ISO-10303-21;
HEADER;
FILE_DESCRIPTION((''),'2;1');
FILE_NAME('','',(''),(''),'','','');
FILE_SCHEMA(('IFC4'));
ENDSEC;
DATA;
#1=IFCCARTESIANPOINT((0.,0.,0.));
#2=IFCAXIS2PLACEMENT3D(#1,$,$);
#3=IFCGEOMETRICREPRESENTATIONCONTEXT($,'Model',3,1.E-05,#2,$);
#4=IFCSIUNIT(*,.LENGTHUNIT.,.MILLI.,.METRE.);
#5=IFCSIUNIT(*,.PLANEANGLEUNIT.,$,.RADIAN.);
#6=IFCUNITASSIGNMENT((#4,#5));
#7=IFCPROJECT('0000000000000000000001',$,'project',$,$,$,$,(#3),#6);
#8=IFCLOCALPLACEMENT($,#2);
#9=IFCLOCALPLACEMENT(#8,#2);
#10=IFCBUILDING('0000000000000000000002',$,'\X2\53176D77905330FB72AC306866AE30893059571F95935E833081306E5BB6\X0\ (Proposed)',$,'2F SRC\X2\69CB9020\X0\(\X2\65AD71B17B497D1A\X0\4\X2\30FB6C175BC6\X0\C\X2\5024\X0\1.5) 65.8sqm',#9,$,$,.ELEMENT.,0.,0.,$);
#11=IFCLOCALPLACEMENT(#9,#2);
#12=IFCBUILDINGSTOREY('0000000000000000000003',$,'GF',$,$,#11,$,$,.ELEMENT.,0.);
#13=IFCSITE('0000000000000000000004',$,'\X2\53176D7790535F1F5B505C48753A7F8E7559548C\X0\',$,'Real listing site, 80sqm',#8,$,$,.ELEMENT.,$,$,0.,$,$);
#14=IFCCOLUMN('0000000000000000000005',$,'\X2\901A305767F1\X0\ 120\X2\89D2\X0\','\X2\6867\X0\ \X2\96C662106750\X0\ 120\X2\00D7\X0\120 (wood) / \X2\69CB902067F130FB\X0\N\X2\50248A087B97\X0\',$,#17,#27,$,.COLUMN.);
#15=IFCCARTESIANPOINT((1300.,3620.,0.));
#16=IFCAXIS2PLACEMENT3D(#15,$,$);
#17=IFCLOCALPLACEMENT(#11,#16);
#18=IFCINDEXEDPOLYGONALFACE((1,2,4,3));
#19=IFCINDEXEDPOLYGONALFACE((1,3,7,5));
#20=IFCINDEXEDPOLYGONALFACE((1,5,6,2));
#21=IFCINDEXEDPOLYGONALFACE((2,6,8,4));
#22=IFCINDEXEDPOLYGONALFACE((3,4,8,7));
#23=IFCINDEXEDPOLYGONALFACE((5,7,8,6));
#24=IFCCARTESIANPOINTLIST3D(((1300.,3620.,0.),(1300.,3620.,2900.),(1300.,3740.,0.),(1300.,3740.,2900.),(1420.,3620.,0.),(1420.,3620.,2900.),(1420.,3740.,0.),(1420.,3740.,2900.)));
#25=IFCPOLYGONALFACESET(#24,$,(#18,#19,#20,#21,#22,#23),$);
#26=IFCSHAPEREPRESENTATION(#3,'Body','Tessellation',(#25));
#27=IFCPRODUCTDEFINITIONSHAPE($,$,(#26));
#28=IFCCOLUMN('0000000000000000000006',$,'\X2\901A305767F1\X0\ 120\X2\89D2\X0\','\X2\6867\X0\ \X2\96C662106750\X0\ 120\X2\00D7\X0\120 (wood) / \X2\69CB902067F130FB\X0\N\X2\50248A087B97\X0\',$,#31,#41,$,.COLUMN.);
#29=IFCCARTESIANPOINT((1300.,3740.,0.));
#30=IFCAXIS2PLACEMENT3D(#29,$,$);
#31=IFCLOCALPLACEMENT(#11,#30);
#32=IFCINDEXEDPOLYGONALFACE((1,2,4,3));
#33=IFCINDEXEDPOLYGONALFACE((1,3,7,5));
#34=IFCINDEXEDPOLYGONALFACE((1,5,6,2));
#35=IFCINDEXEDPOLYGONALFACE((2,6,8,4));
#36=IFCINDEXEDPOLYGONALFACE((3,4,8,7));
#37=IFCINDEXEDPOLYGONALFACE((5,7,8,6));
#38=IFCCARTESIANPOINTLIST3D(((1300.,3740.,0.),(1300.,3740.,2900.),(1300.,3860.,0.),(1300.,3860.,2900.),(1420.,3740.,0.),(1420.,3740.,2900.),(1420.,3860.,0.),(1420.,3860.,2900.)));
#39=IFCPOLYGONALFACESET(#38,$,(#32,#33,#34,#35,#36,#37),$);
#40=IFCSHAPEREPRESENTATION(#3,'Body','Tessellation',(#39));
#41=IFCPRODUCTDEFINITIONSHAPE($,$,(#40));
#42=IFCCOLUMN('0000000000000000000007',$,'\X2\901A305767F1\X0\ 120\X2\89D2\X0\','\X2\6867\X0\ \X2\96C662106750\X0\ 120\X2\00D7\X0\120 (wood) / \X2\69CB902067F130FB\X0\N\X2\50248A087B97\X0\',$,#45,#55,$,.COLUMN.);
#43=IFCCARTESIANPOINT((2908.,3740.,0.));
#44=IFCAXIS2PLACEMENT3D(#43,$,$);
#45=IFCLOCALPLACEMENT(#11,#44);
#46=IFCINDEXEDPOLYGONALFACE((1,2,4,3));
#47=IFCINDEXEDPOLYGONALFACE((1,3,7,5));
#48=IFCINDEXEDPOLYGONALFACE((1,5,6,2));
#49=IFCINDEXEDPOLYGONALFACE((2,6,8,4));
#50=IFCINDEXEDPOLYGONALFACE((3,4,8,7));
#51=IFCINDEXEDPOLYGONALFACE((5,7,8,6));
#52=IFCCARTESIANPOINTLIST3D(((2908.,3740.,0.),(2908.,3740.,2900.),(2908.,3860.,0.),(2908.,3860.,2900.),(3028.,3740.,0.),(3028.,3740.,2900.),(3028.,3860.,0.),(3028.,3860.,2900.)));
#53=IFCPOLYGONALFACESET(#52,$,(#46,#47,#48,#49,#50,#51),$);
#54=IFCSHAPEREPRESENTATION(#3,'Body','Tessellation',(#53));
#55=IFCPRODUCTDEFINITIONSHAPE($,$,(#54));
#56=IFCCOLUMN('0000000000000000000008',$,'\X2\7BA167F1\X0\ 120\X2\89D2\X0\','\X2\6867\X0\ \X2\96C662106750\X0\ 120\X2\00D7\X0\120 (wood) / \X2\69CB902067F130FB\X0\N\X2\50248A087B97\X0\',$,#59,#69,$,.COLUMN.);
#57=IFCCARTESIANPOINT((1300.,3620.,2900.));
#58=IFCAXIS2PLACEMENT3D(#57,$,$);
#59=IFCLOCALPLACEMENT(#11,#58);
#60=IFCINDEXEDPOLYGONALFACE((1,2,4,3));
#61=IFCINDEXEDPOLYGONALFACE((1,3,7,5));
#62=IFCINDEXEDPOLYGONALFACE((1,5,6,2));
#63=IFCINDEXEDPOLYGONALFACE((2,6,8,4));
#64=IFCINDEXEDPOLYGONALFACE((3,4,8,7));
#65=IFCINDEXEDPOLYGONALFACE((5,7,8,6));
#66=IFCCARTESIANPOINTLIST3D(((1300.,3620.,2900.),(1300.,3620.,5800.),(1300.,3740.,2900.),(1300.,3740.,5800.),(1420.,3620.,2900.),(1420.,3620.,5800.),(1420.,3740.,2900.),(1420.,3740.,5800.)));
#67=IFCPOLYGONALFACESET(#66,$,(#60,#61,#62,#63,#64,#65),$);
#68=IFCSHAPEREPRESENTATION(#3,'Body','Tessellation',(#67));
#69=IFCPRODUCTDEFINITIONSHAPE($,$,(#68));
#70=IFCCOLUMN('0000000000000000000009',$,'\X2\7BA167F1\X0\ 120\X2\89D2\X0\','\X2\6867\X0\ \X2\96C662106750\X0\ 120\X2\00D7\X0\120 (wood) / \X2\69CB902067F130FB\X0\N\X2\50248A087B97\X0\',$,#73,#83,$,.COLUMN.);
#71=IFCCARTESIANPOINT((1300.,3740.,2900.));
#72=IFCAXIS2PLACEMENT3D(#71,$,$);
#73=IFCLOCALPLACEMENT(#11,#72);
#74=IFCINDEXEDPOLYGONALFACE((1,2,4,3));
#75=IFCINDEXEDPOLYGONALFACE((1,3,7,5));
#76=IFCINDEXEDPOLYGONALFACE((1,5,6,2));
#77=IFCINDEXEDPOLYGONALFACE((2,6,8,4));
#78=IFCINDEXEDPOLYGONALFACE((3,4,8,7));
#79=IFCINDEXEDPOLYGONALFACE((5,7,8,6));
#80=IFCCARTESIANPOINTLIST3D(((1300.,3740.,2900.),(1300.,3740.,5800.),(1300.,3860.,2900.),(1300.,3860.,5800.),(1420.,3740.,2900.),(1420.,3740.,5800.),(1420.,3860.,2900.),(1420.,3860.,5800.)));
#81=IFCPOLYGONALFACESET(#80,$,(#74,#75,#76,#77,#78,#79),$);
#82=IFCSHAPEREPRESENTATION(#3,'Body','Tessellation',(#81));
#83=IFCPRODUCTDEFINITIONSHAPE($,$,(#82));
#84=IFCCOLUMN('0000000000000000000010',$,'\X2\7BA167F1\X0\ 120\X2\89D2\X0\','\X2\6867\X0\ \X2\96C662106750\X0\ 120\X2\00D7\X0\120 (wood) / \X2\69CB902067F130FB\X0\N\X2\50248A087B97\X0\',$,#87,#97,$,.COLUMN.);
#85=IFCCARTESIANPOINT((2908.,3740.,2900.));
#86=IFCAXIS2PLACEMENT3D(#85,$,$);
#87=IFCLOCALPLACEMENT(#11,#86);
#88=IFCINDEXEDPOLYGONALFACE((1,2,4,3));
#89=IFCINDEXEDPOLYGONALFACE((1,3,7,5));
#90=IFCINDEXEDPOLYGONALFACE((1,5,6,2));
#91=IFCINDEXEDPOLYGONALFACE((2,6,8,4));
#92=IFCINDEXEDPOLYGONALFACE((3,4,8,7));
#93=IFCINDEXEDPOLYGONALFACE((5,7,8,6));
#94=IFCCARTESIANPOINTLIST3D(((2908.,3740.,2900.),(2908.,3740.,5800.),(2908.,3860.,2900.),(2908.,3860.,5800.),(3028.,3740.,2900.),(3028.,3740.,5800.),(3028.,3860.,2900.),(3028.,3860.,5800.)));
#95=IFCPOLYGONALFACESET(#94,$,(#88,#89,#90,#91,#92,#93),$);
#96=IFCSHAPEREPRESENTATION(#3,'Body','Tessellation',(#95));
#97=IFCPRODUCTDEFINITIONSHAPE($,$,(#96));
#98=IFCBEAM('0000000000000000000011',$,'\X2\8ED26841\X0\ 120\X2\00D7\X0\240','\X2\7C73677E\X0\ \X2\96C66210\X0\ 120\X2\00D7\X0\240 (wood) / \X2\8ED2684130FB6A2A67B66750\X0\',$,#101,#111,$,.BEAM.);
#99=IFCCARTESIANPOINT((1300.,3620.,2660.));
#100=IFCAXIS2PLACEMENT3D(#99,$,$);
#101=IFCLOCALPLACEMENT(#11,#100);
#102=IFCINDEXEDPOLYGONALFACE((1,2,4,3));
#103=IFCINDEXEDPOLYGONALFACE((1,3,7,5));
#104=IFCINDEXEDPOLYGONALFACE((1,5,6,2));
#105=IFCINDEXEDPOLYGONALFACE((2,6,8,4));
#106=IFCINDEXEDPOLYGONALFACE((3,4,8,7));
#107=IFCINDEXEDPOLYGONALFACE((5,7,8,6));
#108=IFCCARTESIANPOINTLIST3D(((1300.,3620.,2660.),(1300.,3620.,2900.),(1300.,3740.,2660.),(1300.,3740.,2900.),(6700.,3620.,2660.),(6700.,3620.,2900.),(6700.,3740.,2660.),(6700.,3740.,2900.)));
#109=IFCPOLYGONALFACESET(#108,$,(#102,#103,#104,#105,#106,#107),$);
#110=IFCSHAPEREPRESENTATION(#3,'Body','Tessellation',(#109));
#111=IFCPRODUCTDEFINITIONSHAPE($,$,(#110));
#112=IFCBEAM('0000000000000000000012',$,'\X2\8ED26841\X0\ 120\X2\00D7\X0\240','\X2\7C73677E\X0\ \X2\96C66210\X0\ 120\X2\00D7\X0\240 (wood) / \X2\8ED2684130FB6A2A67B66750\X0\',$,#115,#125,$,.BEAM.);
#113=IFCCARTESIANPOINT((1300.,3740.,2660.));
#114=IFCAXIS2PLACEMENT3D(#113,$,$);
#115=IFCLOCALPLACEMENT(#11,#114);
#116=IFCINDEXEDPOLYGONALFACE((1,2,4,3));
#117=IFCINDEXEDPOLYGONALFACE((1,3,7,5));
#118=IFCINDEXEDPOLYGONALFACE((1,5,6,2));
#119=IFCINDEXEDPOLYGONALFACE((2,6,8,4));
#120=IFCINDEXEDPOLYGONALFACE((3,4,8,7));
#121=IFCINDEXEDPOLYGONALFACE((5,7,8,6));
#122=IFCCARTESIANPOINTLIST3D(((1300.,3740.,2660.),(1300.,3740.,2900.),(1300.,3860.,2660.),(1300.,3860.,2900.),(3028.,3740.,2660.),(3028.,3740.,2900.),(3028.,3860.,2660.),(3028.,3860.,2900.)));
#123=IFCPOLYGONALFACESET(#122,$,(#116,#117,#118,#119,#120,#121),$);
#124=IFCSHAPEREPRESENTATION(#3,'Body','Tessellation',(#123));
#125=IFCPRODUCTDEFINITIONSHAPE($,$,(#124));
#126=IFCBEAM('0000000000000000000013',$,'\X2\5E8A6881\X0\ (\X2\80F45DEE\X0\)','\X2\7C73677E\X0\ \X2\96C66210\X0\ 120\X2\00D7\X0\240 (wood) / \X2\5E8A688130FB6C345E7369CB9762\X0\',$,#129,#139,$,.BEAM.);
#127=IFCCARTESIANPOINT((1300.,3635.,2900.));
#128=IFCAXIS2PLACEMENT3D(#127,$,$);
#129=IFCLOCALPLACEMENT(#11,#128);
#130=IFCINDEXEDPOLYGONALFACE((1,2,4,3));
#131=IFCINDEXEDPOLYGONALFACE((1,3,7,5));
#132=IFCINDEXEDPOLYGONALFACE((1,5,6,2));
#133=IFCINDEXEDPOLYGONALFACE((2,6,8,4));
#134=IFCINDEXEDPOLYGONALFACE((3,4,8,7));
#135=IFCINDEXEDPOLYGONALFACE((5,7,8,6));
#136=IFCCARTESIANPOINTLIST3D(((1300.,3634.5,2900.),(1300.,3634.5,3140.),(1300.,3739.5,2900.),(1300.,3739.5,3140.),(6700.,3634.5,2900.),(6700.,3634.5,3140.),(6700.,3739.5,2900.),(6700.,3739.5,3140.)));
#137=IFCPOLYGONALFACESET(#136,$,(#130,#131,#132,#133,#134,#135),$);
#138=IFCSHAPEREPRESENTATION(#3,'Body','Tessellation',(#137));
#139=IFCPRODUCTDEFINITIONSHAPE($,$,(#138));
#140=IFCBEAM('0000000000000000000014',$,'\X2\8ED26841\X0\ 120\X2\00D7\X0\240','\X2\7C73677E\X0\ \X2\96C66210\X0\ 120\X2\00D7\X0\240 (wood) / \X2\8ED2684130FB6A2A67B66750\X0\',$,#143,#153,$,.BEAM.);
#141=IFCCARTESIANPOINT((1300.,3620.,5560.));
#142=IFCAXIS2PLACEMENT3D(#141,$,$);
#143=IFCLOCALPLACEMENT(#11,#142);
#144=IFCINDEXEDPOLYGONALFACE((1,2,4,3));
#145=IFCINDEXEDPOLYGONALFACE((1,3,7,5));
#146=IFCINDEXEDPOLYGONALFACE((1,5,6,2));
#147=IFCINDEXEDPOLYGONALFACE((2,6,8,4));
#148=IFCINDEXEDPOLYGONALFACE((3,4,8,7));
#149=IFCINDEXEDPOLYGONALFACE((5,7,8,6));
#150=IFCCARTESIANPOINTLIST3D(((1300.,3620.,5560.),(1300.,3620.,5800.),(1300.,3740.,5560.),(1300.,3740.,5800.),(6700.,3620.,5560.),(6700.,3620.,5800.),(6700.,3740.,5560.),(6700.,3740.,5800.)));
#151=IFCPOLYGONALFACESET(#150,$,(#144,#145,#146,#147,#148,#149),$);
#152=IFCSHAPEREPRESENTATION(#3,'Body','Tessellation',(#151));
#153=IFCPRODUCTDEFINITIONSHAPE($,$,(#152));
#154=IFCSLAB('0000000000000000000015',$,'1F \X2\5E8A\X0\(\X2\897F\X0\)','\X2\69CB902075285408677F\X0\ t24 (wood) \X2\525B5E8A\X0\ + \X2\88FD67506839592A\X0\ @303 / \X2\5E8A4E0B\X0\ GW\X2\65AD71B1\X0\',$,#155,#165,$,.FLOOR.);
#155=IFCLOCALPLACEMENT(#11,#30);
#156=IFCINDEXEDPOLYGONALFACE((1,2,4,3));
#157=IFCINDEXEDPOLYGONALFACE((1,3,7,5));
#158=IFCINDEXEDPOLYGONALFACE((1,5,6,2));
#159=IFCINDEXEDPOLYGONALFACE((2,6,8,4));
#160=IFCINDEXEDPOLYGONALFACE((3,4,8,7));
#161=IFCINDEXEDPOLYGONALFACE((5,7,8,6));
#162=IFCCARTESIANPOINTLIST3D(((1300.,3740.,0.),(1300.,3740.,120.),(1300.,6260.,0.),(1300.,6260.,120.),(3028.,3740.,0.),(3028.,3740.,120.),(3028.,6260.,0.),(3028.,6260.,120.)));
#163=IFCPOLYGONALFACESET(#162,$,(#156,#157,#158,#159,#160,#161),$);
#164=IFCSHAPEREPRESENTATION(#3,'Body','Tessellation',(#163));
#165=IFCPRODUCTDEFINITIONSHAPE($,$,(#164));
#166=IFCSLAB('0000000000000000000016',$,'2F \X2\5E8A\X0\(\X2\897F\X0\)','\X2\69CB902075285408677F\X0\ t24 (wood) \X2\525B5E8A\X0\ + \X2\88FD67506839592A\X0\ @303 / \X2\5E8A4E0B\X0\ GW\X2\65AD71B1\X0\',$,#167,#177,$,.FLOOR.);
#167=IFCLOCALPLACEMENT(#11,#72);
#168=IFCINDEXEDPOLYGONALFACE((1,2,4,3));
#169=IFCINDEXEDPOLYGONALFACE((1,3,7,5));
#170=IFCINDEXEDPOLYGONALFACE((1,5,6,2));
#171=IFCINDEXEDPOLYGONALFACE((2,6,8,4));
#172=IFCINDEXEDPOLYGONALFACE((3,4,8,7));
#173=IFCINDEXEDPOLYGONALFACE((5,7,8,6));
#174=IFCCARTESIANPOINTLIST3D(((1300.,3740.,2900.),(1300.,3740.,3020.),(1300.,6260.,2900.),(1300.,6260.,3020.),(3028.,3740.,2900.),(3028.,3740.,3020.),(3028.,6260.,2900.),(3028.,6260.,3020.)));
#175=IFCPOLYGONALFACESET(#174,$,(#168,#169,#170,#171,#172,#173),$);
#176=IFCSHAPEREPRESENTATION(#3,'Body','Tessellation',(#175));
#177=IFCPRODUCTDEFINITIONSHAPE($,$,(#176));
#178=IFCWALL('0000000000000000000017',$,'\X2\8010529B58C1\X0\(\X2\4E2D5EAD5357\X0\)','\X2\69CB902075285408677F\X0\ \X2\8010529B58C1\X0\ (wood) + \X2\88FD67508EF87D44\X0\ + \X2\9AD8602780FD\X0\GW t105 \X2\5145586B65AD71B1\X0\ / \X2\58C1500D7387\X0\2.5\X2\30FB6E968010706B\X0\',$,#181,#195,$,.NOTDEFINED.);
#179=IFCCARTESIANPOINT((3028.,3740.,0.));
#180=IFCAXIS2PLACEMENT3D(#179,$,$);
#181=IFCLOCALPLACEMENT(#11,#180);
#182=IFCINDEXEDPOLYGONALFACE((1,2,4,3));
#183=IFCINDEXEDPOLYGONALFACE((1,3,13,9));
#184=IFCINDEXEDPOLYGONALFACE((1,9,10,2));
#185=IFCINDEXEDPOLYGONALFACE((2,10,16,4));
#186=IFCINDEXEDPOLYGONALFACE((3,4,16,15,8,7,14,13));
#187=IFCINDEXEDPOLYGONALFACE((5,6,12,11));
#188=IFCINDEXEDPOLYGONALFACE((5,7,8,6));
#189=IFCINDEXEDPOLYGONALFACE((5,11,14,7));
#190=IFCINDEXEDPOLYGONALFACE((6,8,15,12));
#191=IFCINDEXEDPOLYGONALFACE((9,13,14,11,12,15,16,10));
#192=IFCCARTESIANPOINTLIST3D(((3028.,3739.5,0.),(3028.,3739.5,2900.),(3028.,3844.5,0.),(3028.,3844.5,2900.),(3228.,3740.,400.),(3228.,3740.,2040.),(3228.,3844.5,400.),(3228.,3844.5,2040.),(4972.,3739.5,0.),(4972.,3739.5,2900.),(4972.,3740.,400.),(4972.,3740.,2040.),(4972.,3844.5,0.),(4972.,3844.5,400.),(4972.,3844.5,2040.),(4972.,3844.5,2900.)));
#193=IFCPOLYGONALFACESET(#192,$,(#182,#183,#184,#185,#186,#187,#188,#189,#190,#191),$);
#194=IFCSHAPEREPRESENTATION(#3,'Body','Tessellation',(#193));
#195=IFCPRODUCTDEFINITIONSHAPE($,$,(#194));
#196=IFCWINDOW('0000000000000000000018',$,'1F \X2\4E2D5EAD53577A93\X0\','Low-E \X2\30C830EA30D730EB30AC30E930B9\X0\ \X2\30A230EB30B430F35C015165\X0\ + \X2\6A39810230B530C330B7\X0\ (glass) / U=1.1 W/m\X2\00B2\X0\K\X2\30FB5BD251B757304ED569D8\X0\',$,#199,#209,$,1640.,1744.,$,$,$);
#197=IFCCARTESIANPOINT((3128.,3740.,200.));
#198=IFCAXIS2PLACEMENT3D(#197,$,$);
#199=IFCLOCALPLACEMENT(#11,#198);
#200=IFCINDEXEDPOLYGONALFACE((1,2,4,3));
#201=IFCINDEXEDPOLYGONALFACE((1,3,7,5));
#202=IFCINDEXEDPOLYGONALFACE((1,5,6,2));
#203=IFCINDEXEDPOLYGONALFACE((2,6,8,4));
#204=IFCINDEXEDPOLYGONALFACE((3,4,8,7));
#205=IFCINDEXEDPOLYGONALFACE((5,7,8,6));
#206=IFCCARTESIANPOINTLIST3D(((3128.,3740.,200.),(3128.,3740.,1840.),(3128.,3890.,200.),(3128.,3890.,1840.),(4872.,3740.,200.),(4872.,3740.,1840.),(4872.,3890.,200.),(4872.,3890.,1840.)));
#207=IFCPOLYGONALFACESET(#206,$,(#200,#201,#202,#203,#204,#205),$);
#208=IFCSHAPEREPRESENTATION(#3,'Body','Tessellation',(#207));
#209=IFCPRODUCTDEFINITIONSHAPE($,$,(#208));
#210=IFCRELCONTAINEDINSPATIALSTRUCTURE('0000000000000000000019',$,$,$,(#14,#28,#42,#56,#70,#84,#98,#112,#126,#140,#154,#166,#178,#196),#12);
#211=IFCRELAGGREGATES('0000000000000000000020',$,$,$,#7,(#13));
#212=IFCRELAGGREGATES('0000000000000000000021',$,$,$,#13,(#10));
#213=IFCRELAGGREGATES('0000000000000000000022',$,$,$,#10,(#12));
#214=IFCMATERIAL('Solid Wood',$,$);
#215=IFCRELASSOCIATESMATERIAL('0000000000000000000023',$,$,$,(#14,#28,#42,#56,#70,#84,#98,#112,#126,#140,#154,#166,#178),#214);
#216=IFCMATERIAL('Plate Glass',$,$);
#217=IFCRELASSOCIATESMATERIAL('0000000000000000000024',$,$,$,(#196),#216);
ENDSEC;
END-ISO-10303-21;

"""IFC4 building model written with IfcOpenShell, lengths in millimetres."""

from ifc_helpers import new_model, si_unit, frame, frame_2d, origin, place, context, project, spatial, rectangle, extrude, material, element, fill, save


model = new_model("IFC4")

# Units and contexts
model_context = context("Model", 3, precision=1e-05, world=origin())
ifc_project = project(units=[si_unit("LENGTHUNIT", "METRE", prefix="MILLI"), si_unit("PLANEANGLEUNIT", "RADIAN")], contexts=[model_context])

# Site, building, storey
site_placement = place(None, origin())
site = spatial("IfcSite", under=ifc_project, at=site_placement, Name="北海道弟子屈町美留和", ObjectType="Real listing site, 80sqm", CompositionType="ELEMENT", RefElevation=0.0)
building_placement = place(site_placement, origin())
building = spatial("IfcBuilding", under=site, at=building_placement, Name="北海道・犬と暮らす土間広めの家 (Proposed)", ObjectType="2F SRC構造(断熱等級4・気密C値1.5) 65.8sqm", CompositionType="ELEMENT", ElevationOfRefHeight=0.0, ElevationOfTerrain=0.0)
storey_placement = place(building_placement, origin())
storey = spatial("IfcBuildingStorey", under=building, at=storey_placement, Name="GF", CompositionType="ELEMENT", Elevation=0.0)

# Columns
ifc_material_1 = material(Name="Solid Wood")
column_1_placement = place(storey_placement, frame((1300.0, 3620.0, 0.0)))
element("IfcColumn", 1, at=column_1_placement, inside=storey, material=ifc_material_1, Name="通し柱 120角", Description="桧 集成材 120×120 (wood) / 構造柱・N値計算", PredefinedType="COLUMN", context=model_context, shape_type="SweptSolid", body=[
    extrude(rectangle(XDim=120.0, YDim=120.0, at=frame_2d((60.0, 60.0))), frame((1300.0, 3620.0, 0.0)), (0.0, 0.0, 1.0), 2900.0),
])
column_2_placement = place(storey_placement, frame((1300.0, 3740.0, 0.0)))
element("IfcColumn", 2, at=column_2_placement, inside=storey, material=ifc_material_1, Name="通し柱 120角", Description="桧 集成材 120×120 (wood) / 構造柱・N値計算", PredefinedType="COLUMN", context=model_context, shape_type="SweptSolid", body=[
    extrude(rectangle(XDim=120.0, YDim=120.0, at=frame_2d((60.0, 60.0))), frame((1300.0, 3740.0, 0.0)), (0.0, 0.0, 1.0), 2900.0),
])
column_3_placement = place(storey_placement, frame((2908.0, 3740.0, 0.0)))
element("IfcColumn", 3, at=column_3_placement, inside=storey, material=ifc_material_1, Name="通し柱 120角", Description="桧 集成材 120×120 (wood) / 構造柱・N値計算", PredefinedType="COLUMN", context=model_context, shape_type="SweptSolid", body=[
    extrude(rectangle(XDim=120.0, YDim=120.0, at=frame_2d((60.0, 60.0))), frame((2908.0, 3740.0, 0.0)), (0.0, 0.0, 1.0), 2900.0),
])
column_4_placement = place(storey_placement, frame((1300.0, 3620.0, 2900.0)))
element("IfcColumn", 4, at=column_4_placement, inside=storey, material=ifc_material_1, Name="管柱 120角", Description="桧 集成材 120×120 (wood) / 構造柱・N値計算", PredefinedType="COLUMN", context=model_context, shape_type="SweptSolid", body=[
    extrude(rectangle(XDim=120.0, YDim=120.0, at=frame_2d((60.0, 60.0))), frame((1300.0, 3620.0, 2900.0)), (0.0, 0.0, 1.0), 2900.0),
])
column_5_placement = place(storey_placement, frame((1300.0, 3740.0, 2900.0)))
element("IfcColumn", 5, at=column_5_placement, inside=storey, material=ifc_material_1, Name="管柱 120角", Description="桧 集成材 120×120 (wood) / 構造柱・N値計算", PredefinedType="COLUMN", context=model_context, shape_type="SweptSolid", body=[
    extrude(rectangle(XDim=120.0, YDim=120.0, at=frame_2d((60.0, 60.0))), frame((1300.0, 3740.0, 2900.0)), (0.0, 0.0, 1.0), 2900.0),
])
column_6_placement = place(storey_placement, frame((2908.0, 3740.0, 2900.0)))
element("IfcColumn", 6, at=column_6_placement, inside=storey, material=ifc_material_1, Name="管柱 120角", Description="桧 集成材 120×120 (wood) / 構造柱・N値計算", PredefinedType="COLUMN", context=model_context, shape_type="SweptSolid", body=[
    extrude(rectangle(XDim=120.0, YDim=120.0, at=frame_2d((60.0, 60.0))), frame((2908.0, 3740.0, 2900.0)), (0.0, 0.0, 1.0), 2900.0),
])

# Beams
beam_1_placement = place(storey_placement, frame((1300.0, 3620.0, 2660.0)))
element("IfcBeam", 7, at=beam_1_placement, inside=storey, material=ifc_material_1, Name="軒桁 120×240", Description="米松 集成 120×240 (wood) / 軒桁・横架材", PredefinedType="BEAM", context=model_context, shape_type="SweptSolid", body=[
    extrude(rectangle(XDim=5400.0, YDim=120.0, at=frame_2d((2700.0, 60.0))), frame((1300.0, 3620.0, 2660.0)), (0.0, 0.0, 1.0), 240.0),
])
beam_2_placement = place(storey_placement, frame((1300.0, 3740.0, 2660.0)))
element("IfcBeam", 8, at=beam_2_placement, inside=storey, material=ifc_material_1, Name="軒桁 120×240", Description="米松 集成 120×240 (wood) / 軒桁・横架材", PredefinedType="BEAM", context=model_context, shape_type="SweptSolid", body=[
    extrude(rectangle(XDim=1728.0, YDim=120.0, at=frame_2d((864.0, 60.0))), frame((1300.0, 3740.0, 2660.0)), (0.0, 0.0, 1.0), 240.0),
])
beam_3_placement = place(storey_placement, frame((1300.0, 3635.0, 2900.0)))
element("IfcBeam", 9, at=beam_3_placement, inside=storey, material=ifc_material_1, Name="床梁 (胴差)", Description="米松 集成 120×240 (wood) / 床梁・水平構面", PredefinedType="BEAM", context=model_context, shape_type="SweptSolid", body=[
    extrude(rectangle(XDim=5400.0, YDim=105.0, at=frame_2d((2700.0, 52.0))), frame((1300.0, 3635.0, 2900.0)), (0.0, 0.0, 1.0), 240.0),
])
beam_4_placement = place(storey_placement, frame((1300.0, 3620.0, 5560.0)))
element("IfcBeam", 10, at=beam_4_placement, inside=storey, material=ifc_material_1, Name="軒桁 120×240", Description="米松 集成 120×240 (wood) / 軒桁・横架材", PredefinedType="BEAM", context=model_context, shape_type="SweptSolid", body=[
    extrude(rectangle(XDim=5400.0, YDim=120.0, at=frame_2d((2700.0, 60.0))), frame((1300.0, 3620.0, 5560.0)), (0.0, 0.0, 1.0), 240.0),
])

# Slabs
slab_1_placement = place(storey_placement, frame((1300.0, 3740.0, 0.0)))
element("IfcSlab", 11, at=slab_1_placement, inside=storey, material=ifc_material_1, Name="1F 床(西)", Description="構造用合板 t24 (wood) 剛床 + 製材根太 @303 / 床下 GW断熱", PredefinedType="FLOOR", context=model_context, shape_type="SweptSolid", body=[
    extrude(rectangle(XDim=1728.0, YDim=2520.0, at=frame_2d((864.0, 1260.0))), frame((1300.0, 3740.0, 0.0)), (0.0, 0.0, 1.0), 120.0),
])
slab_2_placement = place(storey_placement, frame((1300.0, 3740.0, 2900.0)))
element("IfcSlab", 12, at=slab_2_placement, inside=storey, material=ifc_material_1, Name="2F 床(西)", Description="構造用合板 t24 (wood) 剛床 + 製材根太 @303 / 床下 GW断熱", PredefinedType="FLOOR", context=model_context, shape_type="SweptSolid", body=[
    extrude(rectangle(XDim=1728.0, YDim=2520.0, at=frame_2d((864.0, 1260.0))), frame((1300.0, 3740.0, 2900.0)), (0.0, 0.0, 1.0), 120.0),
])

# Wall, opening, window
wall_1_placement = place(storey_placement, frame((3028.0, 3740.0, 0.0)))
wall_1 = element("IfcWall", 13, at=wall_1_placement, inside=storey, material=ifc_material_1, Name="耐力壁(中庭南)", Description="構造用合板 耐力壁 (wood) + 製材軸組 + 高性能GW t105 充填断熱 / 壁倍率2.5・準耐火", PredefinedType="NOTDEFINED", context=model_context, shape_type="SweptSolid", body=[
    extrude(rectangle(XDim=1944.0, YDim=105.0, at=frame_2d((972.0, 52.0))), frame((3028.0, 3740.0, 0.0)), (0.0, 0.0, 1.0), 2900.0),
])
opening_placement = place(storey_placement, frame((3128.0, 3740.0, 200.0)))
opening = element("IfcOpeningElement", 14, at=opening_placement, cuts=wall_1, PredefinedType="NOTDEFINED", context=model_context, shape_type="SweptSolid", body=[
    extrude(rectangle(XDim=1744.0, YDim=150.0, at=frame_2d((872.0, 75.0))), frame((3128.0, 3740.0, 200.0)), (0.0, 0.0, 1.0), 1640.0),
])
ifc_material_2 = material(Name="Plate Glass")
window_1_placement = place(storey_placement, frame((3128.0, 3740.0, 200.0)))
window_1 = element("IfcWindow", 15, at=window_1_placement, inside=storey, material=ifc_material_2, Name="1F 中庭南窓", Description="Low-E トリプルガラス アルゴン封入 + 樹脂サッシ (glass) / U=1.1 W/m²K・寒冷地仕様", OverallHeight=1640.0, OverallWidth=1744.0, context=model_context, shape_type="SweptSolid", body=[
    extrude(rectangle(XDim=1744.0, YDim=150.0, at=frame_2d((872.0, 75.0))), frame((3128.0, 3740.0, 200.0)), (0.0, 0.0, 1.0), 1640.0),
])
fill(opening, window_1)

save(model, "model.ifc")
